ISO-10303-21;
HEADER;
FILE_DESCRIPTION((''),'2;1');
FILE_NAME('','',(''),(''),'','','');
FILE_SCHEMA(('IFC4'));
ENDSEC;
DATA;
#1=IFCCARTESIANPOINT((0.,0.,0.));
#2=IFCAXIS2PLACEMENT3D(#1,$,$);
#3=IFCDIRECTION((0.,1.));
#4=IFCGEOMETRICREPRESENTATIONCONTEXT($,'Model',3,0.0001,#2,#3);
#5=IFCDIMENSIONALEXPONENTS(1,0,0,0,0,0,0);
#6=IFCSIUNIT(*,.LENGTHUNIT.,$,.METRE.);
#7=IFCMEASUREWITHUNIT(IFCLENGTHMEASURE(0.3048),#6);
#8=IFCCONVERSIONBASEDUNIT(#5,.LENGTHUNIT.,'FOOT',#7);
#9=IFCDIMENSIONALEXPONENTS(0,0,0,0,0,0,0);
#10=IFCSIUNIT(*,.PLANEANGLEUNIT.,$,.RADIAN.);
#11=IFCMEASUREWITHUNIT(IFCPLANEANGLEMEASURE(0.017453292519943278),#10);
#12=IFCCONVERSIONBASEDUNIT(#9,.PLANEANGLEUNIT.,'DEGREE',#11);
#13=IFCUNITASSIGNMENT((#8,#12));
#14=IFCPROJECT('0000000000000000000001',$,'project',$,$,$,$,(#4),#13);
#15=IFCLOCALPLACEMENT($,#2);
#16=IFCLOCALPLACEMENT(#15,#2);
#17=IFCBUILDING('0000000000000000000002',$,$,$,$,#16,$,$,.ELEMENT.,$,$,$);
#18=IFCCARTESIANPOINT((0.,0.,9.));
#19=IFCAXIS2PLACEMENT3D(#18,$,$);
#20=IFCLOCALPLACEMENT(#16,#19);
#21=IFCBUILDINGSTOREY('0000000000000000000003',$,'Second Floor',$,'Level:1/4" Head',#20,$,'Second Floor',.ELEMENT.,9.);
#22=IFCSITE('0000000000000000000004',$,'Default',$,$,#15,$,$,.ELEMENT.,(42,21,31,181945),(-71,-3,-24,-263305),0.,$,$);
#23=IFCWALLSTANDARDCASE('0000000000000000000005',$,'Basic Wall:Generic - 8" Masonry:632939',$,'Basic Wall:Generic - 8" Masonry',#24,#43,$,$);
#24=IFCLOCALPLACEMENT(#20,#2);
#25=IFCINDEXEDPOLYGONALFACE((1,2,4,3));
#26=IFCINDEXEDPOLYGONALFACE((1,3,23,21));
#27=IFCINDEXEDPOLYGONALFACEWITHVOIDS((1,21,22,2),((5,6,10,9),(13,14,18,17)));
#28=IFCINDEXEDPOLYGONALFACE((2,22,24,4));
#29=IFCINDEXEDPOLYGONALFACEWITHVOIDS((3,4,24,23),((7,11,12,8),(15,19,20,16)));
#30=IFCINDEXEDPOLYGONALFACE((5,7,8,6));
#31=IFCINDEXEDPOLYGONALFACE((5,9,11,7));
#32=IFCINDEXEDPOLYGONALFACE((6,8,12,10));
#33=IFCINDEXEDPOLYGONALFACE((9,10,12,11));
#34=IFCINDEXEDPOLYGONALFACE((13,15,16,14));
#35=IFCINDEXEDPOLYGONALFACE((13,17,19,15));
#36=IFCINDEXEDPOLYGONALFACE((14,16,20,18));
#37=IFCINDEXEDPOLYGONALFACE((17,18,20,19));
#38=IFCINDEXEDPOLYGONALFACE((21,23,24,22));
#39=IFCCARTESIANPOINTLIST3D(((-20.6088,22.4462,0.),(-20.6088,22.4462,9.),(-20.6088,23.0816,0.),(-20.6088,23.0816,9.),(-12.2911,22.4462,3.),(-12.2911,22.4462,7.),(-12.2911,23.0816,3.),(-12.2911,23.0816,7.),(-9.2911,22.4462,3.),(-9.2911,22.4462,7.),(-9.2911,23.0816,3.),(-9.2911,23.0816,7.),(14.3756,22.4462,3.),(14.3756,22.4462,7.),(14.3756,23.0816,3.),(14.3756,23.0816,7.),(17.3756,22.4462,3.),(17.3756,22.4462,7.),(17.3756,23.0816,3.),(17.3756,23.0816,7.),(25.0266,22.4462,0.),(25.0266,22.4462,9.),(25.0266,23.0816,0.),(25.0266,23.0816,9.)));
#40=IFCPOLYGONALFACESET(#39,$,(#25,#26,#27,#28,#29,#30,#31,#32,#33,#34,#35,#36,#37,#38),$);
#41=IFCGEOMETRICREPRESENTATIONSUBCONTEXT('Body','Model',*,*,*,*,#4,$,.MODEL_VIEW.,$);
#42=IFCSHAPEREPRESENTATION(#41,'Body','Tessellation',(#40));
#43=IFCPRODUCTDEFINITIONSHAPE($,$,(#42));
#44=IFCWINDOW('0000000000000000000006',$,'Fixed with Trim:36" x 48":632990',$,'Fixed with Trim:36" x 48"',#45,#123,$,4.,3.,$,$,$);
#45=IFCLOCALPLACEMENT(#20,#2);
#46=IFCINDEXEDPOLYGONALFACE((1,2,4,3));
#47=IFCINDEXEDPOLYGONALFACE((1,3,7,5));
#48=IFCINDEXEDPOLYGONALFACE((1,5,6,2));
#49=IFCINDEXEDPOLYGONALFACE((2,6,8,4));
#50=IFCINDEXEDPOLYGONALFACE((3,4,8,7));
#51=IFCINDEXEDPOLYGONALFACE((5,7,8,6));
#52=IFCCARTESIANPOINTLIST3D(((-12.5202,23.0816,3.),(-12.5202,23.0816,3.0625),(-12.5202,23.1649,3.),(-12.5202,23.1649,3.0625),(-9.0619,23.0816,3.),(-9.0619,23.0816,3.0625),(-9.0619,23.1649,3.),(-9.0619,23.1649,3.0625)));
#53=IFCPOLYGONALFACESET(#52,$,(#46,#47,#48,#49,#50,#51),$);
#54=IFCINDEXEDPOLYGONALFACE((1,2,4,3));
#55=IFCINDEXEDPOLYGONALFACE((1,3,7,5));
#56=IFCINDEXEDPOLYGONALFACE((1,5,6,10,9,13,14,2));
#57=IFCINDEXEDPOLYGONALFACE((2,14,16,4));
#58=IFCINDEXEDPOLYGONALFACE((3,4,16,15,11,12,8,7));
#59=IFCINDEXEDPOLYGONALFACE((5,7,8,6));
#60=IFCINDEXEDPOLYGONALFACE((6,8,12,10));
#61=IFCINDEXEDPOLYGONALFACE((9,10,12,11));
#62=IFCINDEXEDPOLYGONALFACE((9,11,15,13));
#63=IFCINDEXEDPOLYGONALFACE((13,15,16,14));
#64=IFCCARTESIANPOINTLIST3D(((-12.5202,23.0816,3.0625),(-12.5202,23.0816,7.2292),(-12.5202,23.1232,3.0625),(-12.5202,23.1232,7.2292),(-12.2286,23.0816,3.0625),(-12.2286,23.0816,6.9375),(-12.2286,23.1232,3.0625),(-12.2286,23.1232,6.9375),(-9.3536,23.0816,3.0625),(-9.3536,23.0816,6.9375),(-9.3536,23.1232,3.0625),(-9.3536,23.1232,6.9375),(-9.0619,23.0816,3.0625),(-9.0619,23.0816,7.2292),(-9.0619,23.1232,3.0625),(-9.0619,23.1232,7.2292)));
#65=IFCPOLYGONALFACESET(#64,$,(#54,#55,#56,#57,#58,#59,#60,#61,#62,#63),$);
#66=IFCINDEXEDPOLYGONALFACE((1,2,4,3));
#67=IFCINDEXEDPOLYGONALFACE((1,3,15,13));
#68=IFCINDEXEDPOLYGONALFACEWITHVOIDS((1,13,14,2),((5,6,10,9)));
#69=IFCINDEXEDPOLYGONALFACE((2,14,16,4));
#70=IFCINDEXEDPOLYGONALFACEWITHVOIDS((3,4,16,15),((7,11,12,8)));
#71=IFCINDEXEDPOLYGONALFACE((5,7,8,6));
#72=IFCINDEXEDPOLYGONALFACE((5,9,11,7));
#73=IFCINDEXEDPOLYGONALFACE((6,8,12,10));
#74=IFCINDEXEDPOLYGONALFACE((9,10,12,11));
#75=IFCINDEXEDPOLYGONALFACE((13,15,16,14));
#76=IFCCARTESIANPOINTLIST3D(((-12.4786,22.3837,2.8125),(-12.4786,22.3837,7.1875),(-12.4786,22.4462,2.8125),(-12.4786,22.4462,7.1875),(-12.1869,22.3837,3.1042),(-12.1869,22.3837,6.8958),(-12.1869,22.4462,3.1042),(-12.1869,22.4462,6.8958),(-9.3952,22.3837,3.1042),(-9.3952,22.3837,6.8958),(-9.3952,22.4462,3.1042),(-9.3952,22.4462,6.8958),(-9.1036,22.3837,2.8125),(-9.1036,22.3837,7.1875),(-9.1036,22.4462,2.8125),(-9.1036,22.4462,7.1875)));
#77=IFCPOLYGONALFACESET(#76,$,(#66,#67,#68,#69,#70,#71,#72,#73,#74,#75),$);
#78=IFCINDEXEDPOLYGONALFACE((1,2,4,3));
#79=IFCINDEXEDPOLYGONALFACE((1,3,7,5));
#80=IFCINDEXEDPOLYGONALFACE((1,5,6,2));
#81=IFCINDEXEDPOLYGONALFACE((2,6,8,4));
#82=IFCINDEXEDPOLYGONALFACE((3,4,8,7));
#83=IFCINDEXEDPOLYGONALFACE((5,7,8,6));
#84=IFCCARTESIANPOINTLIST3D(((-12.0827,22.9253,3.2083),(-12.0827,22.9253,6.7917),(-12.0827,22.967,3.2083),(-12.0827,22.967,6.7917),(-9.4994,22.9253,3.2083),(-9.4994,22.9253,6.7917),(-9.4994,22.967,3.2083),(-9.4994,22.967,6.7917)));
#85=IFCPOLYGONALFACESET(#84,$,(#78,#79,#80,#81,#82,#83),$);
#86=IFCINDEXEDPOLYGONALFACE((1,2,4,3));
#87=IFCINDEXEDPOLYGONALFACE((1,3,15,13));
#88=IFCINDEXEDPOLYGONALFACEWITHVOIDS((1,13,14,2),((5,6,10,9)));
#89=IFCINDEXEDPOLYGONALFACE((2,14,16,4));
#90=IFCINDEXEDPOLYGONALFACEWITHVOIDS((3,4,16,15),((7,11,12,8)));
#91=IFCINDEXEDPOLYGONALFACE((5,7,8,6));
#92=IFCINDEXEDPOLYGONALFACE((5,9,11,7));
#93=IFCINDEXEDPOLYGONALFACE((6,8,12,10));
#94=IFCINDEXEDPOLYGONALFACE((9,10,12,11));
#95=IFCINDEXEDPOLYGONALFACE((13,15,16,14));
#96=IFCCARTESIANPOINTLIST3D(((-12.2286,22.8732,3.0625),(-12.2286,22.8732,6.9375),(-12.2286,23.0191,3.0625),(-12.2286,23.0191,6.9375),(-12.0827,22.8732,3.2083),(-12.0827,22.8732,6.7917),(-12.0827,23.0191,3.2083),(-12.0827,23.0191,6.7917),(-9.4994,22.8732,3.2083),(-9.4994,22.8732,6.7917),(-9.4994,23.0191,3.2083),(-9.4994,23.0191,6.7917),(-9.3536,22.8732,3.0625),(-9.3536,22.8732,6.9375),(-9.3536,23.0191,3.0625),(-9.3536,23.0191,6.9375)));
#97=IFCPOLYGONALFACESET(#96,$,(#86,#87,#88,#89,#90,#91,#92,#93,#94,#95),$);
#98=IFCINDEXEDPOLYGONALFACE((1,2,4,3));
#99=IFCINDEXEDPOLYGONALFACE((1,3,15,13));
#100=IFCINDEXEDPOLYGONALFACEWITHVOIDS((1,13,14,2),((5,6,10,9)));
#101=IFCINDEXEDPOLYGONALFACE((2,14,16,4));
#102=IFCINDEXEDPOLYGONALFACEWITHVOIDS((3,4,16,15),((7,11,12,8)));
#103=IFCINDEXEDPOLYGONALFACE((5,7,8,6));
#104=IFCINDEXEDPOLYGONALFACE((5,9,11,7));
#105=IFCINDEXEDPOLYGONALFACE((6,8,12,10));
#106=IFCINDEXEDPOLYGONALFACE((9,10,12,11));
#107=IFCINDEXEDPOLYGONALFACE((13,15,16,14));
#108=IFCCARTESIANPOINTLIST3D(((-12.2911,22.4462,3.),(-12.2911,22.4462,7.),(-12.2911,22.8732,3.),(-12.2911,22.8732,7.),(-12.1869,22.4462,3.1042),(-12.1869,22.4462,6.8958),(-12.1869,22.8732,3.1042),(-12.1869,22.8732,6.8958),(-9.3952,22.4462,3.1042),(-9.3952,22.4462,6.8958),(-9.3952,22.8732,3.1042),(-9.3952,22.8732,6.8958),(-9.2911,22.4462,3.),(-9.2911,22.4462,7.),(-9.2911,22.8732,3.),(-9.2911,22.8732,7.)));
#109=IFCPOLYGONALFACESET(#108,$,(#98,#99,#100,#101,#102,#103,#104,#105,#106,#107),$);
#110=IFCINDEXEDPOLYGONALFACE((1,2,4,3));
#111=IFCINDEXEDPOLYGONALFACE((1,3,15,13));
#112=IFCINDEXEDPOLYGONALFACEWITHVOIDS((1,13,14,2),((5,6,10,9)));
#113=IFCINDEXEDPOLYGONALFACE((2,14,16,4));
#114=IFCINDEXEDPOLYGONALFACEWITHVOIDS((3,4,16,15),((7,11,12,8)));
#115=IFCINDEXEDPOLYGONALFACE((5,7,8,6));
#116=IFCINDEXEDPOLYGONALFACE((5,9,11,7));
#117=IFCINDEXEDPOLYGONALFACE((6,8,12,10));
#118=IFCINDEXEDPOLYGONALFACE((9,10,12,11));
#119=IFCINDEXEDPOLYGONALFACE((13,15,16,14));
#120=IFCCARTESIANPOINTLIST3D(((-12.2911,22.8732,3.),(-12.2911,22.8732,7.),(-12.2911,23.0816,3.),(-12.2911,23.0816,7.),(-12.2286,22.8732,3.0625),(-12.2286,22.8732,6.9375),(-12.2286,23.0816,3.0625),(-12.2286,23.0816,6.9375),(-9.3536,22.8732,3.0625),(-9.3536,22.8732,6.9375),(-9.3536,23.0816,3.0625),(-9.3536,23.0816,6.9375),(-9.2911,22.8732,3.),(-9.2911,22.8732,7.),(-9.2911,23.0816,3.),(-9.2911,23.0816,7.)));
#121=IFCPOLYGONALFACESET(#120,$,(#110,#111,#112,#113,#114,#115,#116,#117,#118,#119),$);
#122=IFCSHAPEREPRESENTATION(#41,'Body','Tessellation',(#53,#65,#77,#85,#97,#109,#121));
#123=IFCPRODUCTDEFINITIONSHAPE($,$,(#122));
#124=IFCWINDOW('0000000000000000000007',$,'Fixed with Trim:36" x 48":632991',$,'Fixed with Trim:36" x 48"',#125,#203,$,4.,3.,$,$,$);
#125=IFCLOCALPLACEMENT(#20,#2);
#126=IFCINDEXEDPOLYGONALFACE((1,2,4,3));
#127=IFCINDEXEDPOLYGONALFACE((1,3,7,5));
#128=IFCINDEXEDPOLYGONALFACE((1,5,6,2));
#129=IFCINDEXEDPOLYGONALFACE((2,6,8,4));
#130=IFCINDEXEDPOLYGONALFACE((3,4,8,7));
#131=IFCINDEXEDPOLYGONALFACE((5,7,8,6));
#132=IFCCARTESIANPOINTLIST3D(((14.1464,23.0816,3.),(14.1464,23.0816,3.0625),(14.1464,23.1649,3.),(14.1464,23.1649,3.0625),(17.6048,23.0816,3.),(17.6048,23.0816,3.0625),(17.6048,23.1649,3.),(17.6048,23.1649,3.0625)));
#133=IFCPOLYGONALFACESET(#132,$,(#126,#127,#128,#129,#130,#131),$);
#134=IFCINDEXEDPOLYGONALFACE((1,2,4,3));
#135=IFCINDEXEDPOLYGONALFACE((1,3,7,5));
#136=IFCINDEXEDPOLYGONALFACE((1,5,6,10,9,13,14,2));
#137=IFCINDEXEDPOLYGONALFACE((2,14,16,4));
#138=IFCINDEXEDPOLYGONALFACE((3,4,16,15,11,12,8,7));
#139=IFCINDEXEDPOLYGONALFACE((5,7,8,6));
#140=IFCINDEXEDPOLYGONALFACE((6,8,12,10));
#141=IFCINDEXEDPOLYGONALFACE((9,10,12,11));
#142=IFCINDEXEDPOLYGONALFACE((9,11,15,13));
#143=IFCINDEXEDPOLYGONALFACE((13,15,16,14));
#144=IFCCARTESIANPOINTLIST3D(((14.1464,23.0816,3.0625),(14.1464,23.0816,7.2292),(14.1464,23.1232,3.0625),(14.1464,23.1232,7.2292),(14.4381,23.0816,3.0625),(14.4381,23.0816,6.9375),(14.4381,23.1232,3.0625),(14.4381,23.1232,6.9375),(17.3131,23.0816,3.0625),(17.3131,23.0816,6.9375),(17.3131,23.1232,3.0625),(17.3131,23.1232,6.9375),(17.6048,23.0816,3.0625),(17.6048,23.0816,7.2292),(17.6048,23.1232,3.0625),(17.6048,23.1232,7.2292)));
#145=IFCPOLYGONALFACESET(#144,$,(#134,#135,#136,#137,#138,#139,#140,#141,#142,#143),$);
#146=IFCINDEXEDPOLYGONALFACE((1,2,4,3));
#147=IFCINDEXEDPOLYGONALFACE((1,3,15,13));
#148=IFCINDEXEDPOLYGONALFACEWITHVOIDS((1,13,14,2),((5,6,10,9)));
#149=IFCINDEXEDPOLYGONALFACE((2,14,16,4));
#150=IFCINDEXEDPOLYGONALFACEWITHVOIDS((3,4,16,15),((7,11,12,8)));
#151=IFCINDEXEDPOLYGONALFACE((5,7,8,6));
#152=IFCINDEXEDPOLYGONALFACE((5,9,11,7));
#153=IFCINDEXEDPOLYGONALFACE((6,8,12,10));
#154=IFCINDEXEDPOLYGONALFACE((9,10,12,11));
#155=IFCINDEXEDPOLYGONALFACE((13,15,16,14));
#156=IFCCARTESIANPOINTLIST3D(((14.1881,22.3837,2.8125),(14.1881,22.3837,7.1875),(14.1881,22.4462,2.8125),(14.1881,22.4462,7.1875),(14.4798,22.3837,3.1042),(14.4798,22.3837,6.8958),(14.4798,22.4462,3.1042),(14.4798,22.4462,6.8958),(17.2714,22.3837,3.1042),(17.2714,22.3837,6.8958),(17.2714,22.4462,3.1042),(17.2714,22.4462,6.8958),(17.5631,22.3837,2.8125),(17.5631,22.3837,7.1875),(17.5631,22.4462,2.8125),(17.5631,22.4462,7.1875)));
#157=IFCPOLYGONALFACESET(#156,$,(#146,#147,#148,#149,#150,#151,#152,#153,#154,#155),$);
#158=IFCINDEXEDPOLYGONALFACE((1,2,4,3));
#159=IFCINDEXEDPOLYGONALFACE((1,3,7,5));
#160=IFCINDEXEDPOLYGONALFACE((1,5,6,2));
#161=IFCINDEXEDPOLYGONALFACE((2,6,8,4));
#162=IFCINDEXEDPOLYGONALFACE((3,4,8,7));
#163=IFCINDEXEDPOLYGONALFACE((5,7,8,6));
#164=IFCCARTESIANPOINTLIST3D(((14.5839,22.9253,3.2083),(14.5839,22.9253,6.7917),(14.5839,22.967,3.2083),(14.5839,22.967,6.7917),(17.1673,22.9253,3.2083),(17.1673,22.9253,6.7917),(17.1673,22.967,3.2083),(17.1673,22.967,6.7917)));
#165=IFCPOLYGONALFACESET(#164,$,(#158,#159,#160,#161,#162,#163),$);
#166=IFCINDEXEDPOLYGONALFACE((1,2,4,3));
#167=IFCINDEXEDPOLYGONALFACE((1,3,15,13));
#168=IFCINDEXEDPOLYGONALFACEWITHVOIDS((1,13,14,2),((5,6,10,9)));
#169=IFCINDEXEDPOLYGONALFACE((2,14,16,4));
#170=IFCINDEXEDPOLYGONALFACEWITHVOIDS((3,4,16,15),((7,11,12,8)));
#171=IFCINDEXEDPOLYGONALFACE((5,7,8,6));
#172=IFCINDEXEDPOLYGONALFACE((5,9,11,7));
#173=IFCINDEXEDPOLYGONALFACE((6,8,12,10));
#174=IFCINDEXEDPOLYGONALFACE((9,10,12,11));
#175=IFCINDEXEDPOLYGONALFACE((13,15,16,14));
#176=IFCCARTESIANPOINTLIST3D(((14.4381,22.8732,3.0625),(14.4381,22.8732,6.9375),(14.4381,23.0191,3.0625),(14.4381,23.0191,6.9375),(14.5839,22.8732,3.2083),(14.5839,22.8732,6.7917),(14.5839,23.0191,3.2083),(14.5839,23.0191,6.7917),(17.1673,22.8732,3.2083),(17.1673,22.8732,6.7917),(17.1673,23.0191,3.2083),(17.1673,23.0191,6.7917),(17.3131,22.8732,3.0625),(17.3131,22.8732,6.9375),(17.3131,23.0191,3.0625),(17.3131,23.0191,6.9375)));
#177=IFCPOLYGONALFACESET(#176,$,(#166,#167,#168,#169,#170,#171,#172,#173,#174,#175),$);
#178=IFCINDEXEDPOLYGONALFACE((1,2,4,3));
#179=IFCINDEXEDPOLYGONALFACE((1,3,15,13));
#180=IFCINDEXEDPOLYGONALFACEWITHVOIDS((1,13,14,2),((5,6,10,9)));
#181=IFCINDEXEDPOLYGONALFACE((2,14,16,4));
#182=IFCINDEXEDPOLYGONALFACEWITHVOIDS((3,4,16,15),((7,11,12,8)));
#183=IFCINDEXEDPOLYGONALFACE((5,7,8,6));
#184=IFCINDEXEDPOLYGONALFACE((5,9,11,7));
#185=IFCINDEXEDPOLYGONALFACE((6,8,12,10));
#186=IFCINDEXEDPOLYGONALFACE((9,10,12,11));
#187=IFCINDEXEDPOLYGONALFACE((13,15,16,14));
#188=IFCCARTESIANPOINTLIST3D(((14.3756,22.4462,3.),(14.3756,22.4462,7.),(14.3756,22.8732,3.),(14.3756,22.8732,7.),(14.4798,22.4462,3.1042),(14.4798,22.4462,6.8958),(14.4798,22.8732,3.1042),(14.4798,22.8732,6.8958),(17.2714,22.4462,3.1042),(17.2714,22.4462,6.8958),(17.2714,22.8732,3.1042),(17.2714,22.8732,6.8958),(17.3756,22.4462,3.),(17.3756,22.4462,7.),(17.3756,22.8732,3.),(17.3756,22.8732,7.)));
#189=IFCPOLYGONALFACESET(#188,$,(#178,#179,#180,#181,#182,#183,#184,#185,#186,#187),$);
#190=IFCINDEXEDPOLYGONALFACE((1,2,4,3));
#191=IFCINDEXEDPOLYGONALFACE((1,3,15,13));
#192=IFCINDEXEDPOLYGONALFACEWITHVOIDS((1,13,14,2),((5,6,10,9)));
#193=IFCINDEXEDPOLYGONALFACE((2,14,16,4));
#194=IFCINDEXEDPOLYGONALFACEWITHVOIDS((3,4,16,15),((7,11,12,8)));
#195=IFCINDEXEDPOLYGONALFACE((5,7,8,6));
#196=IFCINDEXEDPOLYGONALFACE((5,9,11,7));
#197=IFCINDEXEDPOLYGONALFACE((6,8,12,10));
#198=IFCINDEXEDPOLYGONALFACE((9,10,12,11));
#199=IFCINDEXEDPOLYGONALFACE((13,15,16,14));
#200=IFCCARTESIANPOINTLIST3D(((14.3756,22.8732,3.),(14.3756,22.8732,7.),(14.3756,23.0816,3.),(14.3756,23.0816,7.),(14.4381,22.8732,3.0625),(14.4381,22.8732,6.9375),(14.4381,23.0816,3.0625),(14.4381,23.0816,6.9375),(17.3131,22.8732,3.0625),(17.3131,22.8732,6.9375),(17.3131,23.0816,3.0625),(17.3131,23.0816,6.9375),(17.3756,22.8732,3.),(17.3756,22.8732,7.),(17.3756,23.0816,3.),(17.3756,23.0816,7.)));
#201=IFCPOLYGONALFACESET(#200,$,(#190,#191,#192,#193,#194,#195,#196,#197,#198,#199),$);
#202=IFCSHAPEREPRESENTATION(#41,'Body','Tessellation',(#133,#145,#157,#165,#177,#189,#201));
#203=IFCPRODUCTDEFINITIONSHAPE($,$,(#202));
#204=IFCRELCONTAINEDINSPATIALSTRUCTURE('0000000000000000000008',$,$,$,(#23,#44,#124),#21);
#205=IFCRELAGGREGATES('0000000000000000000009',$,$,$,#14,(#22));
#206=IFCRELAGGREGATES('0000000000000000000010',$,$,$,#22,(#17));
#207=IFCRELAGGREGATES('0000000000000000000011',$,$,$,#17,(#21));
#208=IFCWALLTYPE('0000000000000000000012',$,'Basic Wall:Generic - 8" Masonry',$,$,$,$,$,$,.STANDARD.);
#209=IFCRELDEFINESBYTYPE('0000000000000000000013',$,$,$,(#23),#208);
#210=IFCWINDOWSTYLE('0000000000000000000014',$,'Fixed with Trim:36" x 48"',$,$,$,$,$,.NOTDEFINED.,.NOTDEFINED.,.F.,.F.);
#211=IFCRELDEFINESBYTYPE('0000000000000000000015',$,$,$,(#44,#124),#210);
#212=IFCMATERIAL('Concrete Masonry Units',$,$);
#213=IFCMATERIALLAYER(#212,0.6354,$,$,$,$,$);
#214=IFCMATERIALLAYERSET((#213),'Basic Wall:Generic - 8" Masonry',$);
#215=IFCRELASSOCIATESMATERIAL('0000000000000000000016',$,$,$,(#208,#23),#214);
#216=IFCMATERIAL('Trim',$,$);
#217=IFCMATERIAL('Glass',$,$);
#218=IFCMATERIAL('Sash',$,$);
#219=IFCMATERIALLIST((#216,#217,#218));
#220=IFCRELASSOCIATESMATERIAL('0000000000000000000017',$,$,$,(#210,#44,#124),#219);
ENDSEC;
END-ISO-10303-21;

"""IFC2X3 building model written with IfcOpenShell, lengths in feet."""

from ifc_helpers import new_model, entity, si_unit, converted_unit, direction, frame, frame_2d, origin, origin_2d_with_axis, place, context, subcontext, project, spatial, polyline, rectangle, outline, extrude, source, transform, mapped, material, material_list, layer, layer_set, layer_usage, type_object, type_shapes, element, fill, save


model = new_model("IFC2X3")

# Units and contexts
model_context = context("Model", 3, precision=0.0001, world=origin(), true_north=direction((0.0, 1.0)))
body_context = subcontext(model_context, "Body", "Model", "MODEL_VIEW")
ifc_project = project(units=[converted_unit("LENGTHUNIT", "FOOT", entity("IfcLengthMeasure", 0.3048), si_unit("LENGTHUNIT", "METRE"), dimensions=[1, 0, 0, 0, 0, 0, 0]), converted_unit("PLANEANGLEUNIT", "DEGREE", entity("IfcPlaneAngleMeasure", 0.017453292519943278), si_unit("PLANEANGLEUNIT", "RADIAN"), dimensions=[0, 0, 0, 0, 0, 0, 0])], contexts=[model_context])

# Site, building, storey
site_placement = place(None, origin())
site = spatial("IfcSite", under=ifc_project, at=site_placement, Name="Default", CompositionType="ELEMENT", RefLatitude=(42, 21, 31, 181945), RefLongitude=(-71, -3, -24, -263305), RefElevation=0.0)
building_placement = place(site_placement, origin())
building = spatial("IfcBuilding", under=site, at=building_placement, CompositionType="ELEMENT")
storey_placement = place(building_placement, frame((0.0, 0.0, 9.0)))
storey = spatial("IfcBuildingStorey", under=building, at=storey_placement, Name="Second Floor", ObjectType="Level:1/4\" Head", LongName="Second Floor", CompositionType="ELEMENT", Elevation=9.0)

# Wall, openings, windows
ifc_material_1 = material(Name="Concrete Masonry Units")
ifc_layer = layer(ifc_material_1, 0.6354)
ifc_layer_set = layer_set([ifc_layer], Name="Basic Wall:Generic - 8\" Masonry")
ifc_layer_usage_1 = layer_usage(ifc_layer_set, "AXIS2", "NEGATIVE", 0.3177)
wall_type = type_object("IfcWallType", Name="Basic Wall:Generic - 8\" Masonry", PredefinedType="STANDARD", material=ifc_layer_set)
wall_1_placement = place(storey_placement, frame((-20.6088, 22.7639, 0.0)))
wall_1 = element("IfcWallStandardCase", 1, at=wall_1_placement, inside=storey, type_object=wall_type, material=ifc_layer_usage_1, Name="Basic Wall:Generic - 8\" Masonry:632939", ObjectType="Basic Wall:Generic - 8\" Masonry", context=body_context, shape_type="SweptSolid", body=[
    extrude(rectangle(XDim=45.6354, YDim=0.6354, at=frame_2d((22.8177, 0.0), x_axis=(-1.0, 0.0))), origin(), (0.0, 0.0, 1.0), 9.0),
])
opening_1_placement = place(wall_1_placement, frame((8.3177, -0.3177, 3.0)))
opening_1 = element("IfcOpeningElement", 2, at=opening_1_placement, cuts=wall_1, ObjectType="Opening", context=body_context, shape_type="SweptSolid", body=[
    extrude(rectangle(XDim=4.0, YDim=3.0, at=frame_2d((2.0, 1.5), x_axis=(-1.0, 0.0))), frame((0.0, 0.0, 0.0), z_axis=(0.0, 1.0, 0.0), x_axis=(0.0, 0.0, 1.0)), (0.0, 0.0, 1.0), 0.6354),
])
opening_2_placement = place(wall_1_placement, frame((34.9844, -0.3177, 3.0)))
opening_2 = element("IfcOpeningElement", 3, at=opening_2_placement, cuts=wall_1, ObjectType="Opening", context=body_context, shape_type="SweptSolid", body=[
    extrude(rectangle(XDim=4.0, YDim=3.0, at=frame_2d((2.0, 1.5), x_axis=(-1.0, 0.0))), frame((0.0, 0.0, 0.0), z_axis=(0.0, 1.0, 0.0), x_axis=(0.0, 0.0, 1.0)), (0.0, 0.0, 1.0), 0.6354),
])
ifc_material_2 = material(Name="Trim")
ifc_material_3 = material(Name="Glass")
ifc_material_4 = material(Name="Sash")
ifc_material_list_1 = material_list([ifc_material_2, ifc_material_3, ifc_material_4])
window_style = type_object("IfcWindowStyle", Name="Fixed with Trim:36\" x 48\"", ConstructionType="NOTDEFINED", OperationType="NOTDEFINED", ParameterTakesPrecedence=False, Sizeable=False, material=ifc_material_list_1)
shared_shape_1 = source(origin(), body_context, "Body", "SweptSolid", [
    extrude(rectangle(XDim=0.0833, YDim=3.4583, at=origin_2d_with_axis()), frame((1.5, 0.6771, 0.0), z_axis=(0.0, 0.0, 1.0), x_axis=(0.0, -1.0, 0.0)), (0.0, 0.0, 1.0), 0.0625),
    extrude(outline(polyline([(-1.8646, 1.4375), (2.0104, 1.4375), (2.0104, 1.7292), (-2.1562, 1.7292), (-2.1562, -1.7292), (2.0104, -1.7292), (2.0104, -1.4375), (-1.8646, -1.4375), (-1.8646, 1.4375)])), frame((1.5, 0.6354, 2.0729), z_axis=(0.0, 1.0, 0.0), x_axis=(0.0, 0.0, -1.0)), (0.0, 0.0, 1.0), 0.0417),
    extrude(outline(polyline([(-2.1875, -1.6875), (2.1875, -1.6875), (2.1875, 1.6875), (-2.1875, 1.6875), (-2.1875, -1.6875)]), holes=[polyline([(-1.8958, -1.3958), (-1.8958, 1.3958), (1.8958, 1.3958), (1.8958, -1.3958), (-1.8958, -1.3958)])]), frame((1.5, -0.0625, 2.0), z_axis=(0.0, 1.0, 0.0), x_axis=(0.0, 0.0, -1.0)), (0.0, 0.0, 1.0), 0.0625),
    extrude(rectangle(XDim=0.0417, YDim=2.5833, at=frame_2d((0.0, 0.0), x_axis=(1.0, 0.0))), frame((1.5, 0.5, 0.2083), z_axis=(0.0, 0.0, 1.0), x_axis=(0.0, 1.0, 0.0)), (0.0, 0.0, 1.0), 3.5833),
    extrude(outline(polyline([(-1.4375, -1.9375), (1.4375, -1.9375), (1.4375, 1.9375), (-1.4375, 1.9375), (-1.4375, -1.9375)]), holes=[polyline([(-1.2917, -1.7917), (-1.2917, 1.7917), (1.2917, 1.7917), (1.2917, -1.7917), (-1.2917, -1.7917)])]), frame((1.5, 0.4271, 2.0), z_axis=(0.0, 1.0, 0.0), x_axis=(1.0, 0.0, 0.0)), (0.0, 0.0, 1.0), 0.1458),
    extrude(outline(polyline([(-1.5, -2.0), (1.5, -2.0), (1.5, 2.0), (-1.5, 2.0), (-1.5, -2.0)]), holes=[polyline([(-1.3958, -1.8958), (-1.3958, 1.8958), (1.3958, 1.8958), (1.3958, -1.8958), (-1.3958, -1.8958)])]), frame((1.5, 0.0, 2.0), z_axis=(0.0, 1.0, 0.0), x_axis=(1.0, 0.0, 0.0)), (0.0, 0.0, 1.0), 0.4271),
    extrude(outline(polyline([(-2.0, -1.5), (2.0, -1.5), (2.0, 1.5), (-2.0, 1.5), (-2.0, -1.5)]), holes=[polyline([(-1.9375, -1.4375), (-1.9375, 1.4375), (1.9375, 1.4375), (1.9375, -1.4375), (-1.9375, -1.4375)])]), frame((1.5, 0.4271, 2.0), z_axis=(0.0, 1.0, 0.0), x_axis=(0.0, 0.0, -1.0)), (0.0, 0.0, 1.0), 0.2083),
])
type_shapes(window_style, [shared_shape_1])
window_1_placement = place(opening_1_placement, origin())
window_1 = element("IfcWindow", 4, at=window_1_placement, inside=storey, type_object=window_style, material=ifc_material_list_1, Name="Fixed with Trim:36\" x 48\":632990", ObjectType="Fixed with Trim:36\" x 48\"", OverallHeight=4.0, OverallWidth=3.0, context=body_context, shape_type="MappedRepresentation", body=[
    mapped(shared_shape_1, transform((0.0, 0.0, 0.0), scale=1.0)),
])
fill(opening_1, window_1)
window_2_placement = place(opening_2_placement, origin())
window_2 = element("IfcWindow", 5, at=window_2_placement, inside=storey, type_object=window_style, material=ifc_material_list_1, Name="Fixed with Trim:36\" x 48\":632991", ObjectType="Fixed with Trim:36\" x 48\"", OverallHeight=4.0, OverallWidth=3.0, context=body_context, shape_type="MappedRepresentation", body=[
    mapped(shared_shape_1, transform((0.0, 0.0, 0.0), scale=1.0)),
])
fill(opening_2, window_2)

save(model, "model.ifc")
